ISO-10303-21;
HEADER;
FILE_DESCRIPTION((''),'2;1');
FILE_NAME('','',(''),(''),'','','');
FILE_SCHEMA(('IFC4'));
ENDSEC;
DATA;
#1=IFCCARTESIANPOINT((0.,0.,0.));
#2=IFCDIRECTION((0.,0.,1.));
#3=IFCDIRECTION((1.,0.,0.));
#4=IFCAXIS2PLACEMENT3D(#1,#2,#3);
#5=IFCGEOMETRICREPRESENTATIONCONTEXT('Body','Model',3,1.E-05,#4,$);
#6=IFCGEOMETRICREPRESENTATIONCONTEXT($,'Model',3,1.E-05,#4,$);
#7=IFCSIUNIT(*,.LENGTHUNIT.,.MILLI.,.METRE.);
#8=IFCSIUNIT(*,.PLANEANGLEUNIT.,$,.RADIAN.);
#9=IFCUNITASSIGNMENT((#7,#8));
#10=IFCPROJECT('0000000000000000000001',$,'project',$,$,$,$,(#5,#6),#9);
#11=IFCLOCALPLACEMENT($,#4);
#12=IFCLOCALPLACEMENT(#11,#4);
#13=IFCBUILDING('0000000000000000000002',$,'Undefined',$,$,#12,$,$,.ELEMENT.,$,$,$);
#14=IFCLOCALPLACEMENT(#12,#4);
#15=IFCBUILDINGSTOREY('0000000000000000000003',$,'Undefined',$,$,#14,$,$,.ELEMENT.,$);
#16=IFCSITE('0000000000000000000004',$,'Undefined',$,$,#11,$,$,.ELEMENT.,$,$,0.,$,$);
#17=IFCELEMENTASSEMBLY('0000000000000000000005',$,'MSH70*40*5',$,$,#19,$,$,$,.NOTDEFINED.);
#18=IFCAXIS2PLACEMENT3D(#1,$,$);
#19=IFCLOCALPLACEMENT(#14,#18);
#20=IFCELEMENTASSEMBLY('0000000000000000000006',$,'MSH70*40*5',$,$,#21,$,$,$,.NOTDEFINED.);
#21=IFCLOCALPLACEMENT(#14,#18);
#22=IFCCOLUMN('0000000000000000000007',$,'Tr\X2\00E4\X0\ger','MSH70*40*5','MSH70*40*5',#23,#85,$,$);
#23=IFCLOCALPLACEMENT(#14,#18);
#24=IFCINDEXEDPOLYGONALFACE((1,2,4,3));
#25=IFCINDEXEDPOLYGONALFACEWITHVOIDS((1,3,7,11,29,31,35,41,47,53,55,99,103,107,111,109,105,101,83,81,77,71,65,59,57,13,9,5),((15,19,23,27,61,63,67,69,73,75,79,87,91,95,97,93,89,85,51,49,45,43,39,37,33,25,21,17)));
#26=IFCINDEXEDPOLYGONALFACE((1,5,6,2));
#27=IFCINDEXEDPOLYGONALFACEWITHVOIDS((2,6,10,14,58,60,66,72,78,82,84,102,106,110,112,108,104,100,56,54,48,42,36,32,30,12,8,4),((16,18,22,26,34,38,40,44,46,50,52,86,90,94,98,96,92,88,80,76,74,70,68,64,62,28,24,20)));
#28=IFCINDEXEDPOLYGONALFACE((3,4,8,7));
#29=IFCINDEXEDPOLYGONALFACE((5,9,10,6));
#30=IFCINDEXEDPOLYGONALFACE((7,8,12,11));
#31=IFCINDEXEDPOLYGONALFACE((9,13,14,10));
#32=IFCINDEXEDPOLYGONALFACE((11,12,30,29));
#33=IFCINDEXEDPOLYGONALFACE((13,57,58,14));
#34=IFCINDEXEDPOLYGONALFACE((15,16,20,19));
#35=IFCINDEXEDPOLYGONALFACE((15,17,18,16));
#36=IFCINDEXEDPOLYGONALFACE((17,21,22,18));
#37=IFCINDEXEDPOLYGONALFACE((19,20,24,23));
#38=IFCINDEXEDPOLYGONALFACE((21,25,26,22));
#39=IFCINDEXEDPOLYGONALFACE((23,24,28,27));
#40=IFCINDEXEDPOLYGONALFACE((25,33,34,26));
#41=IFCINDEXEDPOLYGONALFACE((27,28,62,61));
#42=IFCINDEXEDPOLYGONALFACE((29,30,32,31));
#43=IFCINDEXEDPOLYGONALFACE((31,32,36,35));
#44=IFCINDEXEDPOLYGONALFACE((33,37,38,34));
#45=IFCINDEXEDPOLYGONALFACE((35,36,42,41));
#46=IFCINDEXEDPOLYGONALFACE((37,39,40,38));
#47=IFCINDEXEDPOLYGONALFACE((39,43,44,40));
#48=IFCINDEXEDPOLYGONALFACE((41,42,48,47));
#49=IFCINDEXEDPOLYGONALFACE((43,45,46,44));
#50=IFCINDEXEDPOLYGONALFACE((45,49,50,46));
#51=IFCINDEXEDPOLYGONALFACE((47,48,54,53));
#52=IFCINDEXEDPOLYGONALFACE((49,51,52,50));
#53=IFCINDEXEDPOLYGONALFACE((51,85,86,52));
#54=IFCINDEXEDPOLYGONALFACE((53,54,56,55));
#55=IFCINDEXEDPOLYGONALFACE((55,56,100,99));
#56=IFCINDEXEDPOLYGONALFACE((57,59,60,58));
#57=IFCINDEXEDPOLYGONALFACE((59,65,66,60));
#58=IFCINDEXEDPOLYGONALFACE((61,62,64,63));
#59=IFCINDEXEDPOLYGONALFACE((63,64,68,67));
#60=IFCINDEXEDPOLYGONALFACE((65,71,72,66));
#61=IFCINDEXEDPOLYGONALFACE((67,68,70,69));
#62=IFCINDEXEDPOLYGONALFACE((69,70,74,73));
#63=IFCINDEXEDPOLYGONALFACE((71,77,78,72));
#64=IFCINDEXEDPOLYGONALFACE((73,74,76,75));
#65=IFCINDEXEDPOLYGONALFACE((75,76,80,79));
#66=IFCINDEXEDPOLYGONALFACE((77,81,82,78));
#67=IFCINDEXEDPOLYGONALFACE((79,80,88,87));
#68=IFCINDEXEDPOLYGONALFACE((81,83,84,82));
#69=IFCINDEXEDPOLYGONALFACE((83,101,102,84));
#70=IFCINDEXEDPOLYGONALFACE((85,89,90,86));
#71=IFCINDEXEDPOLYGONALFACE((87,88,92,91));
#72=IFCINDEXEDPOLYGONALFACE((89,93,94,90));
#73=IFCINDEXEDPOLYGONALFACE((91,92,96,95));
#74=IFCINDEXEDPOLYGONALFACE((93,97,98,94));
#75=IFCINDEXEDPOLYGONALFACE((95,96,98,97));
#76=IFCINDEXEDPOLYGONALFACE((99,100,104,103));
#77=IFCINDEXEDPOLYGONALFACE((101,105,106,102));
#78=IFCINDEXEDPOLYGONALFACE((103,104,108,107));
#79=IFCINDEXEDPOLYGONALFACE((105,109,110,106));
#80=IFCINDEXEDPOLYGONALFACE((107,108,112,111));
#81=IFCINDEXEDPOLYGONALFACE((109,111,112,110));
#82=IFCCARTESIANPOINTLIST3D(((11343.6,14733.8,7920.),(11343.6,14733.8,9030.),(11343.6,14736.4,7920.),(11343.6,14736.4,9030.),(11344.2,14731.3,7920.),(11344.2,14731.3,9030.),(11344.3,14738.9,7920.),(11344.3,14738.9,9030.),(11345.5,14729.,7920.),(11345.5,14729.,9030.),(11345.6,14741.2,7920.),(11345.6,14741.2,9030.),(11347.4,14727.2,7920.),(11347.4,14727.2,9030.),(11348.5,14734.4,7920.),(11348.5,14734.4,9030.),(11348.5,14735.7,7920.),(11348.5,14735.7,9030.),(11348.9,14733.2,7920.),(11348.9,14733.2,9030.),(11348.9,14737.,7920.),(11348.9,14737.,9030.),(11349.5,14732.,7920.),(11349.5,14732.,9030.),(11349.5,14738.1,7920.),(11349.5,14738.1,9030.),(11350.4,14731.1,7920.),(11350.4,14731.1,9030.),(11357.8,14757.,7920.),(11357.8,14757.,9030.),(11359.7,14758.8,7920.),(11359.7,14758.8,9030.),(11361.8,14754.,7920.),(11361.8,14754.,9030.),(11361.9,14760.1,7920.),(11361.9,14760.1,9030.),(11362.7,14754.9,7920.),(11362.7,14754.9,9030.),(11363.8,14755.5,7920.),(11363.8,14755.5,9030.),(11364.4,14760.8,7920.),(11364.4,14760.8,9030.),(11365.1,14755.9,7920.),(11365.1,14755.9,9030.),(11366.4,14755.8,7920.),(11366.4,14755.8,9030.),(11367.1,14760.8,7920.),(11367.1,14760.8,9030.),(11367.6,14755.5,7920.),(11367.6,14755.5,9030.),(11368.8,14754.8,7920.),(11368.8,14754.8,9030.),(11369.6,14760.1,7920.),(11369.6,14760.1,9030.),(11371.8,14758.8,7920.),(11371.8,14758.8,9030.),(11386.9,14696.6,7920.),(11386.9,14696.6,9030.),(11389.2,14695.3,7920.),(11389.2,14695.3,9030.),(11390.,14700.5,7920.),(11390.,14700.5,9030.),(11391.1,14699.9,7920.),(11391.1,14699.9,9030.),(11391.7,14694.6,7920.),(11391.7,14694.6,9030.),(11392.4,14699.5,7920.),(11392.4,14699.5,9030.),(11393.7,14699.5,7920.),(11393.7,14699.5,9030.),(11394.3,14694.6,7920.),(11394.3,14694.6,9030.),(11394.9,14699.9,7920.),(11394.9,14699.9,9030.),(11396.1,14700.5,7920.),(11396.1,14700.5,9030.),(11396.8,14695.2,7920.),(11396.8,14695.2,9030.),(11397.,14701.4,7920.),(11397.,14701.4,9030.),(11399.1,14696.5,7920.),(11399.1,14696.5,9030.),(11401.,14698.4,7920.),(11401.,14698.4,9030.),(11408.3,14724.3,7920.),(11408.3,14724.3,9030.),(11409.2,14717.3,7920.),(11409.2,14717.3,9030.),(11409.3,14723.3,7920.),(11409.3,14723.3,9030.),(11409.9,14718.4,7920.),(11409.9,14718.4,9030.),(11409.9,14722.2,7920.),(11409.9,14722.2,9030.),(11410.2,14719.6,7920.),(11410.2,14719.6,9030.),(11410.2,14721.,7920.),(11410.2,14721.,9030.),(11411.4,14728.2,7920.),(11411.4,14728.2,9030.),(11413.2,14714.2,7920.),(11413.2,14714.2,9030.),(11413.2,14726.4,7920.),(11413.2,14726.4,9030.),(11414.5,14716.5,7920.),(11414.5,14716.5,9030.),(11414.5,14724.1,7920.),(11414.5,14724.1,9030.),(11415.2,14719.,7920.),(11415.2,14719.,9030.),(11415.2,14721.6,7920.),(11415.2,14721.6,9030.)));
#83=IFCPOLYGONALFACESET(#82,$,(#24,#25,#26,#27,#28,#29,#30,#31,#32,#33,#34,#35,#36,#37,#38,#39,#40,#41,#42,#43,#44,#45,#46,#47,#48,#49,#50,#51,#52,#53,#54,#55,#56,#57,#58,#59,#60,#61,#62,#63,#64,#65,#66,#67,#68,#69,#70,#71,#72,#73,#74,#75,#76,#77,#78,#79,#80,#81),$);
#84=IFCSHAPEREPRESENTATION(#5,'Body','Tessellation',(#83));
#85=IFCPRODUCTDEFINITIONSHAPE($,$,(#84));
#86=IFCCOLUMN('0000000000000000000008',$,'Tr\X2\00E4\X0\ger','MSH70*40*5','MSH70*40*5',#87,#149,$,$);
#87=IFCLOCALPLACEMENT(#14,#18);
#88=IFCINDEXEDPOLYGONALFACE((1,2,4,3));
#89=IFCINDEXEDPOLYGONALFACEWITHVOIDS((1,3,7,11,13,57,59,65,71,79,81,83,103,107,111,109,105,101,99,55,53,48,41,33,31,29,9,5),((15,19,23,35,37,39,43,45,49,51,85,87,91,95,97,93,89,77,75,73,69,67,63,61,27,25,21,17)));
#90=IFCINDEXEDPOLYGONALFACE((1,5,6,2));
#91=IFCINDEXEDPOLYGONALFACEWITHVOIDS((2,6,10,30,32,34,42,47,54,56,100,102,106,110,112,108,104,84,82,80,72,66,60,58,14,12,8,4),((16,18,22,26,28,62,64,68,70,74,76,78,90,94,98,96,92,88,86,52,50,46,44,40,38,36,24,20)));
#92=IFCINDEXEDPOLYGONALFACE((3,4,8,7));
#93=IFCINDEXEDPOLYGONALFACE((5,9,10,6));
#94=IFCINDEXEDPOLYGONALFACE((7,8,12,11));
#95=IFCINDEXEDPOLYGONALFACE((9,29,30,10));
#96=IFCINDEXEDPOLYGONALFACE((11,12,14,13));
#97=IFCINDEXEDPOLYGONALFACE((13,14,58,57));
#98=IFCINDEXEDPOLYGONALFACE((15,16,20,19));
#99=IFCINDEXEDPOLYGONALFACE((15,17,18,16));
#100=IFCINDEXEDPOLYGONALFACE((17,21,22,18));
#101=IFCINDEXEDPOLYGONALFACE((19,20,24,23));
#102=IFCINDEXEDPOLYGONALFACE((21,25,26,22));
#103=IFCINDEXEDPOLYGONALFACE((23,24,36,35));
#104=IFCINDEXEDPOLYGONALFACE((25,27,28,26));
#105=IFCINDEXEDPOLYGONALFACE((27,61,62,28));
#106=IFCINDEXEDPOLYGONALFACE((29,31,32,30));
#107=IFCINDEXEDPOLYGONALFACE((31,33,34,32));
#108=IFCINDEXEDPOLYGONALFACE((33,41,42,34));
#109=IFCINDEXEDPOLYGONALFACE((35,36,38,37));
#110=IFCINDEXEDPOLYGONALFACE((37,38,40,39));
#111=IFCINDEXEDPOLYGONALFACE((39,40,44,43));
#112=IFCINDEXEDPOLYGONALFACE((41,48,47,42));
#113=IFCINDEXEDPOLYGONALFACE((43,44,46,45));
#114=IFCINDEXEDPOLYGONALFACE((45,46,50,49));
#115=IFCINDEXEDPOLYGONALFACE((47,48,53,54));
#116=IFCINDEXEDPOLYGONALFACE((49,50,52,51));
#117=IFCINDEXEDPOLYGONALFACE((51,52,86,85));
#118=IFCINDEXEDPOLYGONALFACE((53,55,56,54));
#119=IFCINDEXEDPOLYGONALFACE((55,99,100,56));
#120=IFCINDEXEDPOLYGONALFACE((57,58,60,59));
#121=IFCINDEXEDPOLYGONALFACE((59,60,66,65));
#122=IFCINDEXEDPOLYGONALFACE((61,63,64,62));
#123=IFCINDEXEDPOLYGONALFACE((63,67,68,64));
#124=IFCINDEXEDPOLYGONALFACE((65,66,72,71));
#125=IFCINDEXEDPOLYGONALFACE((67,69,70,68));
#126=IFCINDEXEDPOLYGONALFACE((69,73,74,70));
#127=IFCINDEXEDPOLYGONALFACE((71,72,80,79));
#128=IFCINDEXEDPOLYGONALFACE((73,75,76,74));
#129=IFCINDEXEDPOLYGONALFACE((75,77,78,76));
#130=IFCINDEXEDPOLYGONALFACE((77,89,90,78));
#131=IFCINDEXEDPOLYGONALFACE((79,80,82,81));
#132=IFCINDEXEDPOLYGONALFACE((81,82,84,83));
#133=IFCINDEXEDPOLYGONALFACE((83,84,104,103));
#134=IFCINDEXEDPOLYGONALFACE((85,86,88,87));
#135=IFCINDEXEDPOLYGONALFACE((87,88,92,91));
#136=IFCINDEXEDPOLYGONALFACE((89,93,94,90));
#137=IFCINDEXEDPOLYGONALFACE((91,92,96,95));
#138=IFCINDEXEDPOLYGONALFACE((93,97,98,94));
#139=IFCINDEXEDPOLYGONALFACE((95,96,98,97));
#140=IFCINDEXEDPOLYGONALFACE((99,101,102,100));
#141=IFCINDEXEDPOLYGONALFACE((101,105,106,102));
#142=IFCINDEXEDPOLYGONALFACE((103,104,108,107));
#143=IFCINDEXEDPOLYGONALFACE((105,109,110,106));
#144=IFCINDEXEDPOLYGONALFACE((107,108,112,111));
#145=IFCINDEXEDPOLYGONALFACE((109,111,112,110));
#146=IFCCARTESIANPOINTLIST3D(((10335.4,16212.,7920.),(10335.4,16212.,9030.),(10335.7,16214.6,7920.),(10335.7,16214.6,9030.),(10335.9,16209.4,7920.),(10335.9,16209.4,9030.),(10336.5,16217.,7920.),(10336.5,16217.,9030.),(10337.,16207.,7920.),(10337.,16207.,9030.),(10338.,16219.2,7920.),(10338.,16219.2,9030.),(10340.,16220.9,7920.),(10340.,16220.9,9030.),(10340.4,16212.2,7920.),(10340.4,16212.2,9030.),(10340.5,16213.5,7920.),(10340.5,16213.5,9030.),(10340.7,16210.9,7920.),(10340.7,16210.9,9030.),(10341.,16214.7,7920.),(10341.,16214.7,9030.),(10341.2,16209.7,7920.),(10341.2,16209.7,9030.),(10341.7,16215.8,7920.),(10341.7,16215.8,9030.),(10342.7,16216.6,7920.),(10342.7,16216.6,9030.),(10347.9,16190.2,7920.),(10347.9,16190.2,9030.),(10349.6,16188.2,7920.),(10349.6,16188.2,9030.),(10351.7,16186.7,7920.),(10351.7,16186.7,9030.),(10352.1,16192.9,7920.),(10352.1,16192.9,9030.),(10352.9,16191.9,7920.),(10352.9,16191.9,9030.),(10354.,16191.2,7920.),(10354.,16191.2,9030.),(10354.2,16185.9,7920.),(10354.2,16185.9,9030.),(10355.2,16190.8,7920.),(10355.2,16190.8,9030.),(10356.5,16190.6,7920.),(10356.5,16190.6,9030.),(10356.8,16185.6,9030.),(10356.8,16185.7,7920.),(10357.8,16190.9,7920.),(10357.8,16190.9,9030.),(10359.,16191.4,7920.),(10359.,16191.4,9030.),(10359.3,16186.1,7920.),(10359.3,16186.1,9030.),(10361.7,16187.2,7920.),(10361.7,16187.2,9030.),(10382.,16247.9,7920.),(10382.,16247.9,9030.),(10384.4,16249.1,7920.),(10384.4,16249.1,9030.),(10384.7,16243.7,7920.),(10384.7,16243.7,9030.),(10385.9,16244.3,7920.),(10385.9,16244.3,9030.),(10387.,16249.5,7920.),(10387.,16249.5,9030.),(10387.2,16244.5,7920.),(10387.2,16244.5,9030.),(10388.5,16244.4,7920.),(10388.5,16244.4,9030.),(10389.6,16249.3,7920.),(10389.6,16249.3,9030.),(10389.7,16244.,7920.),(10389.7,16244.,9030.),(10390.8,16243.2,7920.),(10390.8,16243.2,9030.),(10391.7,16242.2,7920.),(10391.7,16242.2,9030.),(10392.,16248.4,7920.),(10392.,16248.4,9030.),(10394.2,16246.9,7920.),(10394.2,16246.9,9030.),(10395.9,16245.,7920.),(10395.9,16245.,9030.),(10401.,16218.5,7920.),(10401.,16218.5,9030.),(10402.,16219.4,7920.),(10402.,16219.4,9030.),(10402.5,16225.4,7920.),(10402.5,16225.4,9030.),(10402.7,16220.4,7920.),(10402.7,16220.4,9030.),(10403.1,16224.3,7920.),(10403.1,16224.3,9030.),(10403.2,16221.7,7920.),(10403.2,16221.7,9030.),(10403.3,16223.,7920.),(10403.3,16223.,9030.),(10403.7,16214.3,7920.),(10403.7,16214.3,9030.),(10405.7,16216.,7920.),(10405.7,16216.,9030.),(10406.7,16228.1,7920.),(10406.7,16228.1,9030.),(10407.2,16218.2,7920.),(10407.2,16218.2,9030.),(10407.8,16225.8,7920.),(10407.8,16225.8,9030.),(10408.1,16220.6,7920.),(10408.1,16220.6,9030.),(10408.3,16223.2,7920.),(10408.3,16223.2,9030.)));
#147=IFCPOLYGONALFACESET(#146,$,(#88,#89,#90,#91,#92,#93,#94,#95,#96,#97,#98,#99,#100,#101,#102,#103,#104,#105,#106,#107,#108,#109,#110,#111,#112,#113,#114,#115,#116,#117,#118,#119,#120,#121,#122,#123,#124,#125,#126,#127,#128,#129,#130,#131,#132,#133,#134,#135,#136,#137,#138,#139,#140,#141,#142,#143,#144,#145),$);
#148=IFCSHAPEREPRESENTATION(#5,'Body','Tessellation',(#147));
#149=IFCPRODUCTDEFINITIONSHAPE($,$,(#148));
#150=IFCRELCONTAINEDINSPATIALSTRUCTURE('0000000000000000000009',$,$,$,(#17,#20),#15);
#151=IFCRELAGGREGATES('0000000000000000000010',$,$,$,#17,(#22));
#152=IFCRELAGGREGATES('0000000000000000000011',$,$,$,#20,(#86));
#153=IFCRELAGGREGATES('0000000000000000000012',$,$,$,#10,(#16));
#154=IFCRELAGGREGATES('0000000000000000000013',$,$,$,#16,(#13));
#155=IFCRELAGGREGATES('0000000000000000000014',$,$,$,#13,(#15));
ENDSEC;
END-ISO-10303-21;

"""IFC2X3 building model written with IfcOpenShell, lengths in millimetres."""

from ifc_helpers import new_model, si_unit, frame, origin_with_axes, origin_2d_with_axis, place, context, project, spatial, hollow_rectangle, extrude, element, aggregate, save


model = new_model("IFC2X3")

# Units and contexts
model_context_1 = context("Model", 3, precision=1e-05, world=origin_with_axes(), identifier="Body")
model_context_2 = context("Model", 3, precision=1e-05, world=origin_with_axes())
ifc_project = project(units=[si_unit("LENGTHUNIT", "METRE", prefix="MILLI"), si_unit("PLANEANGLEUNIT", "RADIAN")], contexts=[model_context_1, model_context_2])

# Site, building, storey
site_placement = place(None, origin_with_axes())
site = spatial("IfcSite", under=ifc_project, at=site_placement, Name="Undefined", CompositionType="ELEMENT", RefElevation=0.0)
building_placement = place(site_placement, origin_with_axes())
building = spatial("IfcBuilding", under=site, at=building_placement, Name="Undefined", CompositionType="ELEMENT")
storey_placement = place(building_placement, origin_with_axes())
storey = spatial("IfcBuildingStorey", under=building, at=storey_placement, Name="Undefined", CompositionType="ELEMENT")

# Element assembly
assembly_1 = element("IfcElementAssembly", 1, inside=storey, Name="MSH70*40*5", PredefinedType="NOTDEFINED")

# Element assembly
assembly_2 = element("IfcElementAssembly", 2, inside=storey, Name="MSH70*40*5", PredefinedType="NOTDEFINED")

# Columns
column_1_placement = place(storey_placement, frame((11379.4, 14727.7, 7920.0), z_axis=(0.0, 0.0, 1.0), x_axis=(1.0, 0.0, 0.0)))
column_1 = element("IfcColumn", 3, at=column_1_placement, Name="Träger", Description="MSH70*40*5", ObjectType="MSH70*40*5", context=model_context_1, shape_type="SweptSolid", body=[
    extrude(hollow_rectangle(XDim=40.0, YDim=70.0, WallThickness=5.0, InnerFilletRadius=5.0, OuterFilletRadius=10.0, at=origin_2d_with_axis()), frame((0.0, 0.0, 1110.0), z_axis=(0.0, 0.0, -1.0), x_axis=(0.611527, 0.791224, 0.000005)), (0.0, 0.0, 1.0), 1110.0),
])
aggregate(assembly_1, [column_1])
column_2_placement = place(storey_placement, frame((10371.9, 16217.6, 7920.0), z_axis=(0.0, 0.0, 1.0), x_axis=(1.0, 0.0, 0.0)))
column_2 = element("IfcColumn", 4, at=column_2_placement, Name="Träger", Description="MSH70*40*5", ObjectType="MSH70*40*5", context=model_context_1, shape_type="SweptSolid", body=[
    extrude(hollow_rectangle(XDim=40.0, YDim=70.0, WallThickness=5.0, InnerFilletRadius=5.0, OuterFilletRadius=10.0, at=origin_2d_with_axis()), frame((0.0, 0.0, 1110.0), z_axis=(0.0, 0.0, -1.0), x_axis=(-0.541855, 0.840472, 0.000005)), (0.0, 0.0, 1.0), 1110.0),
])
aggregate(assembly_2, [column_2])

save(model, "model.ifc")
